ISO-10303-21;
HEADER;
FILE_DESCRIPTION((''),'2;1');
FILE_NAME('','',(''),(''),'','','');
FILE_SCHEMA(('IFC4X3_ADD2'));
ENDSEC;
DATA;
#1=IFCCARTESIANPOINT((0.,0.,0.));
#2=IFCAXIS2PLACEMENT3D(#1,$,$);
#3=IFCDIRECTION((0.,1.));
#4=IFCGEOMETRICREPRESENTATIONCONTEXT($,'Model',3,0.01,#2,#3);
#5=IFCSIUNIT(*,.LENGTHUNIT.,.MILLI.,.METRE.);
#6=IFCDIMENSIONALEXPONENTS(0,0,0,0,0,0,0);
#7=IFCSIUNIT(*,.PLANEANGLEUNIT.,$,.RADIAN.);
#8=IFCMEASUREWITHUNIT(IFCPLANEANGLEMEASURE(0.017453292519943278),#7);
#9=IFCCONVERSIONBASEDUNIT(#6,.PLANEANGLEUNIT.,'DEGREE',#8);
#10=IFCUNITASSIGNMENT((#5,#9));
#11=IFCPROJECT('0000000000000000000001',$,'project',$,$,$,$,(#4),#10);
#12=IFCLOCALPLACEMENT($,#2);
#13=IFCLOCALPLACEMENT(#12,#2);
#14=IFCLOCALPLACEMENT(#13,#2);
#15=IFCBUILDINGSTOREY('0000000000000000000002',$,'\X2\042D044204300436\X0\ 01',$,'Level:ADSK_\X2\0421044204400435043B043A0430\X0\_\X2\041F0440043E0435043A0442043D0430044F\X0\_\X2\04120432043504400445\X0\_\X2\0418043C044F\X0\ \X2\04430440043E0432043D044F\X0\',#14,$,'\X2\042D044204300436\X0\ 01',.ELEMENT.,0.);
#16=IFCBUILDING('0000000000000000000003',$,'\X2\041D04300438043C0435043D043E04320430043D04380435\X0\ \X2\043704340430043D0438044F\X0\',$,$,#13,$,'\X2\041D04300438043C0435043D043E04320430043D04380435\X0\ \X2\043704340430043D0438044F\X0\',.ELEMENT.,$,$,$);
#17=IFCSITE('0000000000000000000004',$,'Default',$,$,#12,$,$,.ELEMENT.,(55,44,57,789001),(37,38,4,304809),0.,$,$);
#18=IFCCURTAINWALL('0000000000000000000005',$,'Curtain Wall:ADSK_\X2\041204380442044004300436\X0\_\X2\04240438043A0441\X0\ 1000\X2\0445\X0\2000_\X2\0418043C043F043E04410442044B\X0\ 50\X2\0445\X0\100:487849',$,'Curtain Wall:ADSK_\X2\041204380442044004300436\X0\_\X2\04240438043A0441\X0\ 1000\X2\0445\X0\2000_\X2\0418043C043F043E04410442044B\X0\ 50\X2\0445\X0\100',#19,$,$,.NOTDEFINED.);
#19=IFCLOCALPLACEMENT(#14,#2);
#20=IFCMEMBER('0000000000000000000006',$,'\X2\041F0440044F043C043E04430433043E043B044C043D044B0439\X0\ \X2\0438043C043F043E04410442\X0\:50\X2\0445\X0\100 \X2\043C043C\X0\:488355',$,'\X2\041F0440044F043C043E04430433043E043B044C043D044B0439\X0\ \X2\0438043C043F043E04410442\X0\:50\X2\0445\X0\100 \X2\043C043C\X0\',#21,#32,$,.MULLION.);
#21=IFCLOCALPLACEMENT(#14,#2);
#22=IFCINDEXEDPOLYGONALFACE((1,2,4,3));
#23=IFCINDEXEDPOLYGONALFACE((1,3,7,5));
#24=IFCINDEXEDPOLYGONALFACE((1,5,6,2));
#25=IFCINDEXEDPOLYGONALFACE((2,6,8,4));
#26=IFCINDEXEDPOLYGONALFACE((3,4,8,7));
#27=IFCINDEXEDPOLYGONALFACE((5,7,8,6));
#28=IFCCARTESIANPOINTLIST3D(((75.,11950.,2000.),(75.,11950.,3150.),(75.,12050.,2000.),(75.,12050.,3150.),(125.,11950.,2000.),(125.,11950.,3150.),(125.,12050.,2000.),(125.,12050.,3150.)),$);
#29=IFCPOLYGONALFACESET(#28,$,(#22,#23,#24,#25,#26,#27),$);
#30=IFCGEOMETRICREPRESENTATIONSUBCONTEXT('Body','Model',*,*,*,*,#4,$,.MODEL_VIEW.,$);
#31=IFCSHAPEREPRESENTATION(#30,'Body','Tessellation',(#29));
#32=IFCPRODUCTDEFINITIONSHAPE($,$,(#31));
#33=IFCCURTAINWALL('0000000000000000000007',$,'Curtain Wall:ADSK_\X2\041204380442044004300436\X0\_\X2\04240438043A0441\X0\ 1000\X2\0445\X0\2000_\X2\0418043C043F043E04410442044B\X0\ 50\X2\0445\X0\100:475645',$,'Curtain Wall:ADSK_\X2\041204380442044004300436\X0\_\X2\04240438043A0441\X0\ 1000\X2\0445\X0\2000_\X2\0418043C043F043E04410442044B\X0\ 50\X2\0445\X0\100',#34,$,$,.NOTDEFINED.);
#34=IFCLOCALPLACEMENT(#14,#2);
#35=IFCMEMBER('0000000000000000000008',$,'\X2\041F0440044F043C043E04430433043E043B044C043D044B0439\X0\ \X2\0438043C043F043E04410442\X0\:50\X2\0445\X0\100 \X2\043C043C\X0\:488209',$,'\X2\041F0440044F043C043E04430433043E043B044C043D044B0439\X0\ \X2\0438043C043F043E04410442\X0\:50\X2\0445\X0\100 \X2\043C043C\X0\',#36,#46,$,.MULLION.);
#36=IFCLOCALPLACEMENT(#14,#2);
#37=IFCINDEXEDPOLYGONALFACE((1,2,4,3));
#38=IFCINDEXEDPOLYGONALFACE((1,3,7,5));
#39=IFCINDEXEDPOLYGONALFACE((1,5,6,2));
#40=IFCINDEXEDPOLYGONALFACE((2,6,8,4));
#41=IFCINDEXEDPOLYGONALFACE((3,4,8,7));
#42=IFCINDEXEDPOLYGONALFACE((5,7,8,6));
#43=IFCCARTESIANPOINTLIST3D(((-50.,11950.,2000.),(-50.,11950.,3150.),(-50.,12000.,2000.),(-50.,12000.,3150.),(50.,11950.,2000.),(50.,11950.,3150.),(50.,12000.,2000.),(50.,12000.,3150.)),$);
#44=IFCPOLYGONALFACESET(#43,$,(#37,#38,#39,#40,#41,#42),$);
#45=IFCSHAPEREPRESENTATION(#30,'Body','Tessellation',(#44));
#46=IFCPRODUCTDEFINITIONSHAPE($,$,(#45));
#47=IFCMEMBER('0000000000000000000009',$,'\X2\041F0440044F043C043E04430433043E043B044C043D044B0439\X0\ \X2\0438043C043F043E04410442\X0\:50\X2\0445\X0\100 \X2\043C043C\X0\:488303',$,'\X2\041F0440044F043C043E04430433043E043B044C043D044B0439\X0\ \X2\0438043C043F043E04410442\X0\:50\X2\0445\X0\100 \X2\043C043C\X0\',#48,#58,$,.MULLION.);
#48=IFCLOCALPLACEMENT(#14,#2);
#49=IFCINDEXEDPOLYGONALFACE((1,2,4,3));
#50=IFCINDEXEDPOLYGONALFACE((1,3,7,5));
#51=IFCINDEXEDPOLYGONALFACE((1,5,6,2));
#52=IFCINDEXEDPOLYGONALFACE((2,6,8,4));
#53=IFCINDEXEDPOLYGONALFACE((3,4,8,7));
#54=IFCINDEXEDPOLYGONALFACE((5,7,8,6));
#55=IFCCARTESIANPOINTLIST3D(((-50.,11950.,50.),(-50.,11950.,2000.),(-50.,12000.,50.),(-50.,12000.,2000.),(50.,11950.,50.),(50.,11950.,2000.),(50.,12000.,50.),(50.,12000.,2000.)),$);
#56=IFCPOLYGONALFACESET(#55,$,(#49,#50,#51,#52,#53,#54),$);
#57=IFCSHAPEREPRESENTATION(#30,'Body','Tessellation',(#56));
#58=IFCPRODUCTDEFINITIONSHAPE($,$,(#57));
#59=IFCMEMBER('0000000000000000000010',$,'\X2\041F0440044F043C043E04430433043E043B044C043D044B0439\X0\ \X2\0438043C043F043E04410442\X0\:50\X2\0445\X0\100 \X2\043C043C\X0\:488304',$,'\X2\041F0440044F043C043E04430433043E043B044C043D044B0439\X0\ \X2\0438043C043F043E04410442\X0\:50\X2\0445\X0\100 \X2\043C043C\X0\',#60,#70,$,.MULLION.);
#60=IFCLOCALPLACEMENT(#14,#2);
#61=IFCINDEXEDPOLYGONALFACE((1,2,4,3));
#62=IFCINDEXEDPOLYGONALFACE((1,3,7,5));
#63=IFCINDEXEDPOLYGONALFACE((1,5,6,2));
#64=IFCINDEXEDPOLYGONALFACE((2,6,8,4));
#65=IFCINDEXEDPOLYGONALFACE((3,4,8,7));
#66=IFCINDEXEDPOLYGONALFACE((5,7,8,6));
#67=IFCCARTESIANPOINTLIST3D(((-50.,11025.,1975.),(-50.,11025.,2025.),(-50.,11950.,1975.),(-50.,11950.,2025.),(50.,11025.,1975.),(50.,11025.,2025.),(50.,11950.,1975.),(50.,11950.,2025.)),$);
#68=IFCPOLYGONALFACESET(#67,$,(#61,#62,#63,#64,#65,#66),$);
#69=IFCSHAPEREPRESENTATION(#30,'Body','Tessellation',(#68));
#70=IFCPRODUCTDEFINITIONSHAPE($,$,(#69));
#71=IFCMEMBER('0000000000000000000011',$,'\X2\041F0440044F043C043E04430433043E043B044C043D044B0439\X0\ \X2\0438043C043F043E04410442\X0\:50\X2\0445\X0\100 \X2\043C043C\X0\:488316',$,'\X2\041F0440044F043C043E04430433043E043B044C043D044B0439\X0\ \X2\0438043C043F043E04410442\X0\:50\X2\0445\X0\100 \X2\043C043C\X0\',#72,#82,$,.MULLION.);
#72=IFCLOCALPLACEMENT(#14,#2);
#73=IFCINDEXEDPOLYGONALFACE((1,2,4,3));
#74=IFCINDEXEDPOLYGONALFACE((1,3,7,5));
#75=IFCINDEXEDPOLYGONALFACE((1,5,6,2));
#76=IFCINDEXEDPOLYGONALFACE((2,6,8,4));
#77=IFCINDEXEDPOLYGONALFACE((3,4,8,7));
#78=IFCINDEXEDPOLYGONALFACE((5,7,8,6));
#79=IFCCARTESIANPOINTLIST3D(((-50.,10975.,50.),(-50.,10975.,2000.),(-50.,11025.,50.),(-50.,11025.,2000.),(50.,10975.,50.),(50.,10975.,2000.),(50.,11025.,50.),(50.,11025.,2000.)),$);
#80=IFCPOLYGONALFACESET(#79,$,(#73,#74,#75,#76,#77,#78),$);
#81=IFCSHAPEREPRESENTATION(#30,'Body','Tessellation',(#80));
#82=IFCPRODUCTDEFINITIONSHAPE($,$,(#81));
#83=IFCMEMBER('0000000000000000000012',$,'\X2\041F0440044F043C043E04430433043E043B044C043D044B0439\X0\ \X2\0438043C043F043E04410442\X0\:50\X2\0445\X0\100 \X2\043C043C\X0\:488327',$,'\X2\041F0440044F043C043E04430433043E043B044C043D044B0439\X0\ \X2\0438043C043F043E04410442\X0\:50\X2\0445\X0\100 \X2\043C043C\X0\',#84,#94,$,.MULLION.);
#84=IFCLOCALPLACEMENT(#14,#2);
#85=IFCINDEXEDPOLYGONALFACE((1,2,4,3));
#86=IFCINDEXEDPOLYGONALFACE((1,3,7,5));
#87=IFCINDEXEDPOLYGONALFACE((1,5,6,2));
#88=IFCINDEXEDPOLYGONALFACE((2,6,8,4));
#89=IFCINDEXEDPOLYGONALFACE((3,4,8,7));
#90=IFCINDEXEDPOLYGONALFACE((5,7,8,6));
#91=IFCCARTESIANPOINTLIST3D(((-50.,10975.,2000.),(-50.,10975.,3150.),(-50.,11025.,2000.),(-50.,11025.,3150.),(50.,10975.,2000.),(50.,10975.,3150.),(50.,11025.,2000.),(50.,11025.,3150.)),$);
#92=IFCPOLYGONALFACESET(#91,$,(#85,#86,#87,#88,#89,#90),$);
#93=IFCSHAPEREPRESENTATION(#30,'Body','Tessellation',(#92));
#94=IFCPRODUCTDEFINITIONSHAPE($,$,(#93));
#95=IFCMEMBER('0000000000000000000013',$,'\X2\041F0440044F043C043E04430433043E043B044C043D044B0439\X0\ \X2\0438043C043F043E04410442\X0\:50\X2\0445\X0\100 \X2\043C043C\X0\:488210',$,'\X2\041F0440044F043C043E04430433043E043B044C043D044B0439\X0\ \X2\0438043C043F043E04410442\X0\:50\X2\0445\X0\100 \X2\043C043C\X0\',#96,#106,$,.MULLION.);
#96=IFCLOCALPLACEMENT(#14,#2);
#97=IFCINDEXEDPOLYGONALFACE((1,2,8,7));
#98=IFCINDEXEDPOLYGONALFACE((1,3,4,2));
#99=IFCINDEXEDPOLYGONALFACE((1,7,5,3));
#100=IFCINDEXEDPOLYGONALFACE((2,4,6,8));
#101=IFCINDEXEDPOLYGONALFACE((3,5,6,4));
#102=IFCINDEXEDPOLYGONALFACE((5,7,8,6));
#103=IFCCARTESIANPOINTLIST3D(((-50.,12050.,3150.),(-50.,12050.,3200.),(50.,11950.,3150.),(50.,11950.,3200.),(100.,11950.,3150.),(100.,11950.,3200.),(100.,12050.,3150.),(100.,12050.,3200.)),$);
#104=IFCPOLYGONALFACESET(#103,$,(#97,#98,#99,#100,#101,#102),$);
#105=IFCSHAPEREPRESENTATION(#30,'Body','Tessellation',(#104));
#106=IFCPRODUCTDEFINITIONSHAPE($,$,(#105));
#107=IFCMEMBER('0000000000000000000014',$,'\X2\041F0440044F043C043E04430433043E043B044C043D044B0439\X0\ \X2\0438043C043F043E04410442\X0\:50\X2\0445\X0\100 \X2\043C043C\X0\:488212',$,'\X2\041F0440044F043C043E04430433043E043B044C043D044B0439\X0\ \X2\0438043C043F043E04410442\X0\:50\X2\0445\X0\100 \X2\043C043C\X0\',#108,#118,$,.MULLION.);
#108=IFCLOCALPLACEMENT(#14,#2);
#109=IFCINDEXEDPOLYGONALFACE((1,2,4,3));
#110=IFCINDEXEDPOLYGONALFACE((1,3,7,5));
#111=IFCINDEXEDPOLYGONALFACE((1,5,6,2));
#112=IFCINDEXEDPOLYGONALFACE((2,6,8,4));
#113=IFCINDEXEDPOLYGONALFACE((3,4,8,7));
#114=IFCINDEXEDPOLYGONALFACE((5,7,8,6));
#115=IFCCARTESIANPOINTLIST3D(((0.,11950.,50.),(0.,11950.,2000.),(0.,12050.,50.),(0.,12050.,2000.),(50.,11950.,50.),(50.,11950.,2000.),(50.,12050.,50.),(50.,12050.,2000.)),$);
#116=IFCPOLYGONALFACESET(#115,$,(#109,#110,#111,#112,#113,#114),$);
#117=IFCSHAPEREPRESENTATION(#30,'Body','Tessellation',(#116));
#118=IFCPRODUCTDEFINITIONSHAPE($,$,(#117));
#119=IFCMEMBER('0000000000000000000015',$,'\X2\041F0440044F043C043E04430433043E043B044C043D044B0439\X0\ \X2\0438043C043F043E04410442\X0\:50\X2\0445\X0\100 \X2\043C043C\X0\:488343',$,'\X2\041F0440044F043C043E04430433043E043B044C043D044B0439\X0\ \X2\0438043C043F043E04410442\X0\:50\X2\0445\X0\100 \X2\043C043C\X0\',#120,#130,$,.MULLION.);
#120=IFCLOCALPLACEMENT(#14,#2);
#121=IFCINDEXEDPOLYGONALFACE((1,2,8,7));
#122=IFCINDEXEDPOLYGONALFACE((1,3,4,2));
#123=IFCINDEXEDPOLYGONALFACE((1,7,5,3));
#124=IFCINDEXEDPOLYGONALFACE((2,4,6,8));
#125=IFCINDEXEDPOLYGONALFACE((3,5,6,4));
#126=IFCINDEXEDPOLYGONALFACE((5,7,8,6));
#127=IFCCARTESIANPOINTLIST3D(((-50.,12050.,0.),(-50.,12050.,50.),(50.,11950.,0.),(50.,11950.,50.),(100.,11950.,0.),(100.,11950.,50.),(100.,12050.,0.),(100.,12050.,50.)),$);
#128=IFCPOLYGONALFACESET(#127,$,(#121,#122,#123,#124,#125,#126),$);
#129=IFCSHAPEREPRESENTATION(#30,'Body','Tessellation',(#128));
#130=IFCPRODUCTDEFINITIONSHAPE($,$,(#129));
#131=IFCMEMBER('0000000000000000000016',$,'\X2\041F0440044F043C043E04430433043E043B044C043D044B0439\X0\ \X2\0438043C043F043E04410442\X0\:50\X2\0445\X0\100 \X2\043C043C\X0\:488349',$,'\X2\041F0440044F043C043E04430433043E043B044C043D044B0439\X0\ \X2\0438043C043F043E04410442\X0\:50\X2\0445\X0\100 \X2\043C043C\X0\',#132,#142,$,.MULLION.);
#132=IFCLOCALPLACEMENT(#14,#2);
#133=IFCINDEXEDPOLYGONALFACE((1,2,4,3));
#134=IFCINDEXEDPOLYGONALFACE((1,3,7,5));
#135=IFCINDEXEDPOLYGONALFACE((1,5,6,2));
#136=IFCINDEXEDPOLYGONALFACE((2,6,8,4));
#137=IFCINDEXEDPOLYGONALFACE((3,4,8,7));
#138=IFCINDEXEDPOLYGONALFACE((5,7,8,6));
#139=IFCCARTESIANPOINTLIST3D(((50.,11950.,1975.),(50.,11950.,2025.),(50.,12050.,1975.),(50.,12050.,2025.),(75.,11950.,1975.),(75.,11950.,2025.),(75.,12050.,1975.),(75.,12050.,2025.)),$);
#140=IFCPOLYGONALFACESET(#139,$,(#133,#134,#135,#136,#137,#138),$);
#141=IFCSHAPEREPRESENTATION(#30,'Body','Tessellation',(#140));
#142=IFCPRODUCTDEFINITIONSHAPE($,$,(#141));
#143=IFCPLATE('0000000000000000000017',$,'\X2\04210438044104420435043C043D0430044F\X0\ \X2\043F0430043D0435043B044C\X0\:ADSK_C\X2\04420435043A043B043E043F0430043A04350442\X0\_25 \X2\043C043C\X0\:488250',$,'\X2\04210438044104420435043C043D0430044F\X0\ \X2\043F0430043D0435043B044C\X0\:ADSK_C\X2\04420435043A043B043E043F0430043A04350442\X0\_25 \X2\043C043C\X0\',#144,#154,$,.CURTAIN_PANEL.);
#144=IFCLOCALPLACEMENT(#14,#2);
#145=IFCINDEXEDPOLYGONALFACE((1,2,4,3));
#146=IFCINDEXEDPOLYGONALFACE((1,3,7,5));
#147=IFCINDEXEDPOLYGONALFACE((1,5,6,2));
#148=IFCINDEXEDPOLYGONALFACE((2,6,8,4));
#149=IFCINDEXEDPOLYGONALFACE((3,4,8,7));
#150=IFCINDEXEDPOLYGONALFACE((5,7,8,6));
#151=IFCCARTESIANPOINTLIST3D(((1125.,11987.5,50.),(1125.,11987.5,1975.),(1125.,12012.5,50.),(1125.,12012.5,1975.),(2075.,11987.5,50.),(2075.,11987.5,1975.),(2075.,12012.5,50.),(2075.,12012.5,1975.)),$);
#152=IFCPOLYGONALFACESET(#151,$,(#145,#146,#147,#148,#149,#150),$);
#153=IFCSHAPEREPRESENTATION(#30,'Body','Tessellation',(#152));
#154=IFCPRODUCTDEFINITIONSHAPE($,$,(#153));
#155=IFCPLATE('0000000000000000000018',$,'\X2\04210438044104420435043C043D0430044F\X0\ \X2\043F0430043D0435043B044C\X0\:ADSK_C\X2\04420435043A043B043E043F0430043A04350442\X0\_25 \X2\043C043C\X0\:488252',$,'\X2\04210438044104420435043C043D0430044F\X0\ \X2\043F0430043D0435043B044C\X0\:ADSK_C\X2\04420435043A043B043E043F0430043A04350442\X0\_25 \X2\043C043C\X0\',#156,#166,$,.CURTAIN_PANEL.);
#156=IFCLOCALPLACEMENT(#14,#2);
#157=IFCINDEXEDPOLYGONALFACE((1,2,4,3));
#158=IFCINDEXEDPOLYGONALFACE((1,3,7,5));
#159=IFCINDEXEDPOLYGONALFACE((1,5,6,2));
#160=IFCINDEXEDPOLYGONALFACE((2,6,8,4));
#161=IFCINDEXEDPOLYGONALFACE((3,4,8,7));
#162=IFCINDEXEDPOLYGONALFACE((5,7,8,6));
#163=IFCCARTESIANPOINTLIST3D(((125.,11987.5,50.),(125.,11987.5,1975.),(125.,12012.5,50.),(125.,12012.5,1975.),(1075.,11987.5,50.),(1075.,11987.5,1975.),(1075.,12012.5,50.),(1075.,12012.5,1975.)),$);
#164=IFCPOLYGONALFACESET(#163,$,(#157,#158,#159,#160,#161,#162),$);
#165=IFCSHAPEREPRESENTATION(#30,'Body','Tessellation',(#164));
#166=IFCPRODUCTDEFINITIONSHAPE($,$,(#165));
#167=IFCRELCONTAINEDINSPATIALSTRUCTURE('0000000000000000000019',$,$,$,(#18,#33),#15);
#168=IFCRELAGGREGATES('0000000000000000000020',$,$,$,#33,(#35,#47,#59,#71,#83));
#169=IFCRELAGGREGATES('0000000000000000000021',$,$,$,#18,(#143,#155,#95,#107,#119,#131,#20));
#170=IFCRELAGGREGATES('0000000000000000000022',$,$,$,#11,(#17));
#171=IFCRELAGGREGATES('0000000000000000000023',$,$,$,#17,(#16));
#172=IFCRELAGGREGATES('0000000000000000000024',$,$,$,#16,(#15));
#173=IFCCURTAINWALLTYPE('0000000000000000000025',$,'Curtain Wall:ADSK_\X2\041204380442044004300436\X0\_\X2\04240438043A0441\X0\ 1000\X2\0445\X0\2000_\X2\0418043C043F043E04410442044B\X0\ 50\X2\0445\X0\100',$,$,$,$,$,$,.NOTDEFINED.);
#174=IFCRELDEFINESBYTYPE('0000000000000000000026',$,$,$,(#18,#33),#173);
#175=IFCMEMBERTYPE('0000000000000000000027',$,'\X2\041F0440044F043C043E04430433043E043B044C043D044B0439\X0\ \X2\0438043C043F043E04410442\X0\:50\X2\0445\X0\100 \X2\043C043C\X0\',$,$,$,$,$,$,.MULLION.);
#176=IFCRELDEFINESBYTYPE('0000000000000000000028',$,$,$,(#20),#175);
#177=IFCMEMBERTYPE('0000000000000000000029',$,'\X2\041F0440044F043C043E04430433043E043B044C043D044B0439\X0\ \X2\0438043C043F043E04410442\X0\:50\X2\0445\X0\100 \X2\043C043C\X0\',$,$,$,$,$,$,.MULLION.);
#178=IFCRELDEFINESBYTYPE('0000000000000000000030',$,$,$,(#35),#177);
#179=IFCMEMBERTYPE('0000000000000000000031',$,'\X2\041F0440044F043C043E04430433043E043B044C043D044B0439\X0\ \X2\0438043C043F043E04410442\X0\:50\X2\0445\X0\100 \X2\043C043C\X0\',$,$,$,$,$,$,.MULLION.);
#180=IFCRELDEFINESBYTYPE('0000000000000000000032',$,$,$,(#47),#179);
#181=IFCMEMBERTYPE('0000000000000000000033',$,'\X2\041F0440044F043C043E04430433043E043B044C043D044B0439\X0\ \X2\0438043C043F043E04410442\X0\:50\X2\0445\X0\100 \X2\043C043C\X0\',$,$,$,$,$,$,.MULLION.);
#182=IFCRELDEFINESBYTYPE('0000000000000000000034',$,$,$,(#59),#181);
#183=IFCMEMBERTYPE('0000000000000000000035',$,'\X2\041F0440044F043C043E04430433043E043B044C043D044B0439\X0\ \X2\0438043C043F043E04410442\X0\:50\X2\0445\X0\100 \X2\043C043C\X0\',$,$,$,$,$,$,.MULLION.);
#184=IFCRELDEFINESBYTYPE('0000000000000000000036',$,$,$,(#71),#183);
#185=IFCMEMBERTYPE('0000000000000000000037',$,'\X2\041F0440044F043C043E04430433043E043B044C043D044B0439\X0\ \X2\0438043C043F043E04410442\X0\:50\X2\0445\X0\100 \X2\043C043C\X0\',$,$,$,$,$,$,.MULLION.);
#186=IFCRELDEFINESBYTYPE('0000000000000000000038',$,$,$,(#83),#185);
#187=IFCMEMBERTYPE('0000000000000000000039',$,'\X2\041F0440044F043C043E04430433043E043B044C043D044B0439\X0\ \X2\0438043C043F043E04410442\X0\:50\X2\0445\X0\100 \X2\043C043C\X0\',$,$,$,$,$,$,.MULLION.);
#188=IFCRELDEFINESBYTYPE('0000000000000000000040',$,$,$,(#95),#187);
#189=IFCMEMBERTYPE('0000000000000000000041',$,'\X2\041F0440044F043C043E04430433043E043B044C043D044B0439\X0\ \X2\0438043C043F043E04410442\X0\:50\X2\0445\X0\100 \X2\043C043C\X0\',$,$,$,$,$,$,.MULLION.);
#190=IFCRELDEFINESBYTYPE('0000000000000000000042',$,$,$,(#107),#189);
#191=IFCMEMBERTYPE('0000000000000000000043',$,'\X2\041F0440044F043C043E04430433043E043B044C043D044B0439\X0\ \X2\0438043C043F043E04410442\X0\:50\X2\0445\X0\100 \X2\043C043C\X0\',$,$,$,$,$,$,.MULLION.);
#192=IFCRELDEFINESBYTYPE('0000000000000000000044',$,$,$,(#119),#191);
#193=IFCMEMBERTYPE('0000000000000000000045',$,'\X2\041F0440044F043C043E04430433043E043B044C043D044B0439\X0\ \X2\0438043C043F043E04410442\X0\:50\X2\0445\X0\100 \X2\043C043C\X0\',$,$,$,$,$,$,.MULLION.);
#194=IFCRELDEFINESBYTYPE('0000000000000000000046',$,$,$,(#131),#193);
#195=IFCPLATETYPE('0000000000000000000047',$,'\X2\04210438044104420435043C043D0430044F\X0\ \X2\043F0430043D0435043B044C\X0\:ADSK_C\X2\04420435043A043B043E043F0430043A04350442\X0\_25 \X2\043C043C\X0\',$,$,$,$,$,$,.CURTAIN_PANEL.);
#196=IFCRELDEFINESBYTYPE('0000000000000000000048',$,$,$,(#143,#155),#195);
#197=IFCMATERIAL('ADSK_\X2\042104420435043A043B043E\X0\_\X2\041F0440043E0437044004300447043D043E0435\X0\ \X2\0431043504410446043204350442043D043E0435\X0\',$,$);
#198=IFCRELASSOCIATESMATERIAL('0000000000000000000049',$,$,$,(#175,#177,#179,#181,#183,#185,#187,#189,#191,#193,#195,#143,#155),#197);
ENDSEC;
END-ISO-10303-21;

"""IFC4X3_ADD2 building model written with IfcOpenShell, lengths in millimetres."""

from ifc_helpers import new_model, entity, si_unit, converted_unit, direction, frame, frame_2d, origin, origin_2d_with_axis, place, context, subcontext, project, spatial, polyline, rectangle, outline, extrude, source, transform, mapped, material, material_profile, profile_set, type_object, type_shapes, element, aggregate, save


model = new_model("IFC4X3_ADD2")

# Units and contexts
model_context = context("Model", 3, precision=0.01, world=origin(), true_north=direction((0.0, 1.0)))
body_context = subcontext(model_context, "Body", "Model", "MODEL_VIEW")
ifc_project = project(units=[si_unit("LENGTHUNIT", "METRE", prefix="MILLI"), converted_unit("PLANEANGLEUNIT", "DEGREE", entity("IfcPlaneAngleMeasure", 0.017453292519943278), si_unit("PLANEANGLEUNIT", "RADIAN"), dimensions=[0, 0, 0, 0, 0, 0, 0])], contexts=[model_context])

# Site, building, storey
site_placement = place(None, origin())
site = spatial("IfcSite", under=ifc_project, at=site_placement, Name="Default", CompositionType="ELEMENT", RefLatitude=(55, 44, 57, 789001), RefLongitude=(37, 38, 4, 304809), RefElevation=0.0)
building_placement = place(site_placement, origin())
building = spatial("IfcBuilding", under=site, at=building_placement, Name="Наименование здания", LongName="Наименование здания", CompositionType="ELEMENT")
storey_placement = place(building_placement, origin())
storey = spatial("IfcBuildingStorey", under=building, at=storey_placement, Name="Этаж 01", ObjectType="Level:ADSK_Стрелка_Проектная_Вверх_Имя уровня", LongName="Этаж 01", CompositionType="ELEMENT", Elevation=0.0)

# Curtain walls, members
curtain_wall_type = type_object("IfcCurtainWallType", Name="Curtain Wall:ADSK_Витраж_Фикс 1000х2000_Импосты 50х100", PredefinedType="NOTDEFINED")
curtain_wall_1_placement = place(storey_placement, origin())
curtain_wall_1 = element("IfcCurtainWall", 1, at=curtain_wall_1_placement, inside=storey, type_object=curtain_wall_type, Name="Curtain Wall:ADSK_Витраж_Фикс 1000х2000_Импосты 50х100:487849", ObjectType="Curtain Wall:ADSK_Витраж_Фикс 1000х2000_Импосты 50х100", PredefinedType="NOTDEFINED")
ifc_material = material(Name="ADSK_Стекло_Прозрачное бесцветное")
ifc_material_profile = material_profile(ifc_material, rectangle(XDim=50.0, YDim=100.0, at=frame_2d((0.0, 0.0), x_axis=(1.0, 0.0))), Name="50х100 мм")
ifc_profile_set = profile_set([ifc_material_profile], Name="50х100 мм")
member_type_1 = type_object("IfcMemberType", Name="Прямоугольный импост:50х100 мм", PredefinedType="MULLION", material=ifc_profile_set)
shared_shape_1 = source(origin(), body_context, "Body", "SweptSolid", [
    extrude(rectangle(XDim=50.0, YDim=100.0, at=frame_2d((0.0, 0.0), x_axis=(1.0, 0.0))), frame((0.0, 0.0, -1150.0), z_axis=(0.0, 0.0, 1.0), x_axis=(-1.0, 0.0, 0.0)), (0.0, 0.0, 1.0), 1150.0),
])
type_shapes(member_type_1, [shared_shape_1])
member_1_placement = place(curtain_wall_1_placement, frame((100.0, 12000.0, 2000.0), z_axis=(0.0, 0.0, -1.0), x_axis=(-1.0, 0.0, 0.0)))
member_1 = element("IfcMember", 2, at=member_1_placement, type_object=member_type_1, Name="Прямоугольный импост:50х100 мм:488355", ObjectType="Прямоугольный импост:50х100 мм", PredefinedType="MULLION", context=body_context, shape_type="MappedRepresentation", body=[
    mapped(shared_shape_1, transform((0.0, 0.0, 0.0), scale=1.0)),
])
curtain_wall_2_placement = place(storey_placement, origin())
curtain_wall_2 = element("IfcCurtainWall", 3, at=curtain_wall_2_placement, inside=storey, type_object=curtain_wall_type, Name="Curtain Wall:ADSK_Витраж_Фикс 1000х2000_Импосты 50х100:475645", ObjectType="Curtain Wall:ADSK_Витраж_Фикс 1000х2000_Импосты 50х100", PredefinedType="NOTDEFINED")
member_type_2 = type_object("IfcMemberType", Name="Прямоугольный импост:50х100 мм", PredefinedType="MULLION", material=ifc_profile_set)
shared_shape_2 = source(origin(), body_context, "Body", "SweptSolid", [
    extrude(rectangle(XDim=50.0, YDim=100.0, at=frame_2d((0.0, 0.0), x_axis=(1.0, 0.0))), frame((-25.0, 0.0, -1150.0), z_axis=(0.0, 0.0, 1.0), x_axis=(-1.0, 0.0, 0.0)), (0.0, 0.0, 1.0), 1150.0),
])
type_shapes(member_type_2, [shared_shape_2])
member_2_placement = place(curtain_wall_2_placement, frame((0.0, 12000.0, 3150.0), z_axis=(0.0, 0.0, 1.0), x_axis=(0.0, 1.0, 0.0)))
member_2 = element("IfcMember", 4, at=member_2_placement, type_object=member_type_2, Name="Прямоугольный импост:50х100 мм:488209", ObjectType="Прямоугольный импост:50х100 мм", PredefinedType="MULLION", context=body_context, shape_type="MappedRepresentation", body=[
    mapped(shared_shape_2, transform((0.0, 0.0, 0.0), scale=1.0)),
])
member_type_3 = type_object("IfcMemberType", Name="Прямоугольный импост:50х100 мм", PredefinedType="MULLION", material=ifc_profile_set)
shared_shape_3 = source(origin(), body_context, "Body", "SweptSolid", [
    extrude(rectangle(XDim=50.0, YDim=100.0, at=frame_2d((0.0, 0.0), x_axis=(1.0, 0.0))), frame((-25.0, 0.0, -1950.0), z_axis=(0.0, 0.0, 1.0), x_axis=(-1.0, 0.0, 0.0)), (0.0, 0.0, 1.0), 1950.0),
])
type_shapes(member_type_3, [shared_shape_3])
member_3_placement = place(curtain_wall_2_placement, frame((0.0, 12000.0, 2000.0), z_axis=(0.0, 0.0, 1.0), x_axis=(0.0, 1.0, 0.0)))
member_3 = element("IfcMember", 5, at=member_3_placement, type_object=member_type_3, Name="Прямоугольный импост:50х100 мм:488303", ObjectType="Прямоугольный импост:50х100 мм", PredefinedType="MULLION", context=body_context, shape_type="MappedRepresentation", body=[
    mapped(shared_shape_3, transform((0.0, 0.0, 0.0), scale=1.0)),
])
member_type_4 = type_object("IfcMemberType", Name="Прямоугольный импост:50х100 мм", PredefinedType="MULLION", material=ifc_profile_set)
shared_shape_4 = source(origin(), body_context, "Body", "SweptSolid", [
    extrude(rectangle(XDim=50.0, YDim=100.0, at=frame_2d((0.0, 0.0), x_axis=(1.0, 0.0))), frame((0.0, 0.0, -925.0), z_axis=(0.0, 0.0, 1.0), x_axis=(-1.0, 0.0, 0.0)), (0.0, 0.0, 1.0), 925.0),
])
type_shapes(member_type_4, [shared_shape_4])
member_4_placement = place(curtain_wall_2_placement, frame((0.0, 11025.0, 2000.0), z_axis=(0.0, -1.0, 0.0), x_axis=(0.0, 0.0, 1.0)))
member_4 = element("IfcMember", 6, at=member_4_placement, type_object=member_type_4, Name="Прямоугольный импост:50х100 мм:488304", ObjectType="Прямоугольный импост:50х100 мм", PredefinedType="MULLION", context=body_context, shape_type="MappedRepresentation", body=[
    mapped(shared_shape_4, transform((0.0, 0.0, 0.0), scale=1.0)),
])
member_type_5 = type_object("IfcMemberType", Name="Прямоугольный импост:50х100 мм", PredefinedType="MULLION", material=ifc_profile_set)
shared_shape_5 = source(origin(), body_context, "Body", "SweptSolid", [
    extrude(rectangle(XDim=50.0, YDim=100.0, at=frame_2d((0.0, 0.0), x_axis=(1.0, 0.0))), frame((0.0, 0.0, -1950.0), z_axis=(0.0, 0.0, 1.0), x_axis=(-1.0, 0.0, 0.0)), (0.0, 0.0, 1.0), 1950.0),
])
type_shapes(member_type_5, [shared_shape_5])
member_5_placement = place(curtain_wall_2_placement, frame((0.0, 11000.0, 50.0), z_axis=(0.0, 0.0, -1.0), x_axis=(0.0, -1.0, 0.0)))
member_5 = element("IfcMember", 7, at=member_5_placement, type_object=member_type_5, Name="Прямоугольный импост:50х100 мм:488316", ObjectType="Прямоугольный импост:50х100 мм", PredefinedType="MULLION", context=body_context, shape_type="MappedRepresentation", body=[
    mapped(shared_shape_5, transform((0.0, 0.0, 0.0), scale=1.0)),
])
member_type_6 = type_object("IfcMemberType", Name="Прямоугольный импост:50х100 мм", PredefinedType="MULLION", material=ifc_profile_set)
shared_shape_6 = source(origin(), body_context, "Body", "SweptSolid", [
    extrude(rectangle(XDim=50.0, YDim=100.0, at=frame_2d((0.0, 0.0), x_axis=(1.0, 0.0))), frame((0.0, 0.0, -1150.0), z_axis=(0.0, 0.0, 1.0), x_axis=(-1.0, 0.0, 0.0)), (0.0, 0.0, 1.0), 1150.0),
])
type_shapes(member_type_6, [shared_shape_6])
member_6_placement = place(curtain_wall_2_placement, frame((0.0, 11000.0, 2000.0), z_axis=(0.0, 0.0, -1.0), x_axis=(0.0, -1.0, 0.0)))
member_6 = element("IfcMember", 8, at=member_6_placement, type_object=member_type_6, Name="Прямоугольный импост:50х100 мм:488327", ObjectType="Прямоугольный импост:50х100 мм", PredefinedType="MULLION", context=body_context, shape_type="MappedRepresentation", body=[
    mapped(shared_shape_6, transform((0.0, 0.0, 0.0), scale=1.0)),
])

# Members
member_type_7 = type_object("IfcMemberType", Name="Прямоугольный импост:50х100 мм", PredefinedType="MULLION", material=ifc_profile_set)
shared_shape_7 = source(origin(), body_context, "Body", "SweptSolid", [
    extrude(outline(polyline([(0.0, -50.0), (50.0, -50.0), (50.0, 50.0), (-100.0, 50.0), (0.0, -50.0)])), frame((-50.0, 0.0, -50.0), z_axis=(1.0, 0.0, 0.0), x_axis=(0.0, 0.0, -1.0)), (0.0, 0.0, 1.0), 50.0),
])
type_shapes(member_type_7, [shared_shape_7])
member_7_placement = place(curtain_wall_1_placement, frame((0.0, 12000.0, 3200.0), z_axis=(-1.0, 0.0, 0.0), x_axis=(0.0, 0.0, 1.0)))
member_7 = element("IfcMember", 9, at=member_7_placement, type_object=member_type_7, Name="Прямоугольный импост:50х100 мм:488210", ObjectType="Прямоугольный импост:50х100 мм", PredefinedType="MULLION", context=body_context, shape_type="MappedRepresentation", body=[
    mapped(shared_shape_7, transform((0.0, 0.0, 0.0), scale=1.0)),
])
member_type_8 = type_object("IfcMemberType", Name="Прямоугольный импост:50х100 мм", PredefinedType="MULLION", material=ifc_profile_set)
shared_shape_8 = source(origin(), body_context, "Body", "SweptSolid", [
    extrude(rectangle(XDim=50.0, YDim=100.0, at=frame_2d((0.0, 0.0), x_axis=(1.0, 0.0))), frame((-25.0, 0.0, -1950.0), z_axis=(0.0, 0.0, 1.0), x_axis=(-1.0, 0.0, 0.0)), (0.0, 0.0, 1.0), 1950.0),
])
type_shapes(member_type_8, [shared_shape_8])
member_8_placement = place(curtain_wall_1_placement, frame((0.0, 12000.0, 50.0), z_axis=(0.0, 0.0, -1.0), x_axis=(-1.0, 0.0, 0.0)))
member_8 = element("IfcMember", 10, at=member_8_placement, type_object=member_type_8, Name="Прямоугольный импост:50х100 мм:488212", ObjectType="Прямоугольный импост:50х100 мм", PredefinedType="MULLION", context=body_context, shape_type="MappedRepresentation", body=[
    mapped(shared_shape_8, transform((0.0, 0.0, 0.0), scale=1.0)),
])
member_type_9 = type_object("IfcMemberType", Name="Прямоугольный импост:50х100 мм", PredefinedType="MULLION", material=ifc_profile_set)
shared_shape_9 = source(origin(), body_context, "Body", "SweptSolid", [
    extrude(outline(polyline([(-50.0, -50.0), (0.0, -50.0), (100.0, 50.0), (-50.0, 50.0), (-50.0, -50.0)])), frame((-50.0, 0.0, -50.0), z_axis=(1.0, 0.0, 0.0), x_axis=(0.0, 0.0, -1.0)), (0.0, 0.0, 1.0), 50.0),
])
type_shapes(member_type_9, [shared_shape_9])
member_9_placement = place(curtain_wall_1_placement, frame((100.0, 12000.0, 0.0), z_axis=(1.0, 0.0, 0.0), x_axis=(0.0, 0.0, -1.0)))
member_9 = element("IfcMember", 11, at=member_9_placement, type_object=member_type_9, Name="Прямоугольный импост:50х100 мм:488343", ObjectType="Прямоугольный импост:50х100 мм", PredefinedType="MULLION", context=body_context, shape_type="MappedRepresentation", body=[
    mapped(shared_shape_9, transform((0.0, 0.0, 0.0), scale=1.0)),
])
member_type_10 = type_object("IfcMemberType", Name="Прямоугольный импост:50х100 мм", PredefinedType="MULLION", material=ifc_profile_set)
shared_shape_10 = source(origin(), body_context, "Body", "SweptSolid", [
    extrude(rectangle(XDim=50.0, YDim=100.0, at=frame_2d((0.0, 0.0), x_axis=(1.0, 0.0))), frame((0.0, 0.0, -25.0), z_axis=(0.0, 0.0, 1.0), x_axis=(-1.0, 0.0, 0.0)), (0.0, 0.0, 1.0), 25.0),
])
type_shapes(member_type_10, [shared_shape_10])
member_10_placement = place(curtain_wall_1_placement, frame((50.0, 12000.0, 2000.0), z_axis=(-1.0, 0.0, 0.0), x_axis=(0.0, 0.0, 1.0)))
member_10 = element("IfcMember", 12, at=member_10_placement, type_object=member_type_10, Name="Прямоугольный импост:50х100 мм:488349", ObjectType="Прямоугольный импост:50х100 мм", PredefinedType="MULLION", context=body_context, shape_type="MappedRepresentation", body=[
    mapped(shared_shape_10, transform((0.0, 0.0, 0.0), scale=1.0)),
])

# Plates
plate_type_1 = type_object("IfcPlateType", Name="Системная панель:ADSK_Cтеклопакет_25 мм", PredefinedType="CURTAIN_PANEL", material=ifc_material)
shared_shape_11 = source(origin(), body_context, "Body", "SweptSolid", [
    extrude(rectangle(XDim=25.0, YDim=950.0, at=origin_2d_with_axis()), frame((0.0, 0.0, 0.0), z_axis=(0.0, 0.0, 1.0), x_axis=(0.0, 1.0, 0.0)), (0.0, 0.0, 1.0), 1925.0),
])
type_shapes(plate_type_1, [shared_shape_11])
plate_1_placement = place(curtain_wall_1_placement, frame((1600.0, 12000.0, 50.0), z_axis=(0.0, 0.0, 1.0), x_axis=(-1.0, 0.0, 0.0)))
plate_1 = element("IfcPlate", 13, at=plate_1_placement, type_object=plate_type_1, material=ifc_material, Name="Системная панель:ADSK_Cтеклопакет_25 мм:488250", ObjectType="Системная панель:ADSK_Cтеклопакет_25 мм", PredefinedType="CURTAIN_PANEL", context=body_context, shape_type="MappedRepresentation", body=[
    mapped(shared_shape_11, transform((0.0, 0.0, 0.0), scale=1.0)),
])
plate_2_placement = place(curtain_wall_1_placement, frame((600.0, 12000.0, 50.0), z_axis=(0.0, 0.0, 1.0), x_axis=(-1.0, 0.0, 0.0)))
plate_2 = element("IfcPlate", 14, at=plate_2_placement, type_object=plate_type_1, material=ifc_material, Name="Системная панель:ADSK_Cтеклопакет_25 мм:488252", ObjectType="Системная панель:ADSK_Cтеклопакет_25 мм", PredefinedType="CURTAIN_PANEL", context=body_context, shape_type="MappedRepresentation", body=[
    mapped(shared_shape_11, transform((0.0, 0.0, 0.0), scale=1.0)),
])
aggregate(curtain_wall_2, [member_2, member_3, member_4, member_5, member_6])
aggregate(curtain_wall_1, [plate_1, plate_2, member_7, member_8, member_9, member_10, member_1])

save(model, "model.ifc")
